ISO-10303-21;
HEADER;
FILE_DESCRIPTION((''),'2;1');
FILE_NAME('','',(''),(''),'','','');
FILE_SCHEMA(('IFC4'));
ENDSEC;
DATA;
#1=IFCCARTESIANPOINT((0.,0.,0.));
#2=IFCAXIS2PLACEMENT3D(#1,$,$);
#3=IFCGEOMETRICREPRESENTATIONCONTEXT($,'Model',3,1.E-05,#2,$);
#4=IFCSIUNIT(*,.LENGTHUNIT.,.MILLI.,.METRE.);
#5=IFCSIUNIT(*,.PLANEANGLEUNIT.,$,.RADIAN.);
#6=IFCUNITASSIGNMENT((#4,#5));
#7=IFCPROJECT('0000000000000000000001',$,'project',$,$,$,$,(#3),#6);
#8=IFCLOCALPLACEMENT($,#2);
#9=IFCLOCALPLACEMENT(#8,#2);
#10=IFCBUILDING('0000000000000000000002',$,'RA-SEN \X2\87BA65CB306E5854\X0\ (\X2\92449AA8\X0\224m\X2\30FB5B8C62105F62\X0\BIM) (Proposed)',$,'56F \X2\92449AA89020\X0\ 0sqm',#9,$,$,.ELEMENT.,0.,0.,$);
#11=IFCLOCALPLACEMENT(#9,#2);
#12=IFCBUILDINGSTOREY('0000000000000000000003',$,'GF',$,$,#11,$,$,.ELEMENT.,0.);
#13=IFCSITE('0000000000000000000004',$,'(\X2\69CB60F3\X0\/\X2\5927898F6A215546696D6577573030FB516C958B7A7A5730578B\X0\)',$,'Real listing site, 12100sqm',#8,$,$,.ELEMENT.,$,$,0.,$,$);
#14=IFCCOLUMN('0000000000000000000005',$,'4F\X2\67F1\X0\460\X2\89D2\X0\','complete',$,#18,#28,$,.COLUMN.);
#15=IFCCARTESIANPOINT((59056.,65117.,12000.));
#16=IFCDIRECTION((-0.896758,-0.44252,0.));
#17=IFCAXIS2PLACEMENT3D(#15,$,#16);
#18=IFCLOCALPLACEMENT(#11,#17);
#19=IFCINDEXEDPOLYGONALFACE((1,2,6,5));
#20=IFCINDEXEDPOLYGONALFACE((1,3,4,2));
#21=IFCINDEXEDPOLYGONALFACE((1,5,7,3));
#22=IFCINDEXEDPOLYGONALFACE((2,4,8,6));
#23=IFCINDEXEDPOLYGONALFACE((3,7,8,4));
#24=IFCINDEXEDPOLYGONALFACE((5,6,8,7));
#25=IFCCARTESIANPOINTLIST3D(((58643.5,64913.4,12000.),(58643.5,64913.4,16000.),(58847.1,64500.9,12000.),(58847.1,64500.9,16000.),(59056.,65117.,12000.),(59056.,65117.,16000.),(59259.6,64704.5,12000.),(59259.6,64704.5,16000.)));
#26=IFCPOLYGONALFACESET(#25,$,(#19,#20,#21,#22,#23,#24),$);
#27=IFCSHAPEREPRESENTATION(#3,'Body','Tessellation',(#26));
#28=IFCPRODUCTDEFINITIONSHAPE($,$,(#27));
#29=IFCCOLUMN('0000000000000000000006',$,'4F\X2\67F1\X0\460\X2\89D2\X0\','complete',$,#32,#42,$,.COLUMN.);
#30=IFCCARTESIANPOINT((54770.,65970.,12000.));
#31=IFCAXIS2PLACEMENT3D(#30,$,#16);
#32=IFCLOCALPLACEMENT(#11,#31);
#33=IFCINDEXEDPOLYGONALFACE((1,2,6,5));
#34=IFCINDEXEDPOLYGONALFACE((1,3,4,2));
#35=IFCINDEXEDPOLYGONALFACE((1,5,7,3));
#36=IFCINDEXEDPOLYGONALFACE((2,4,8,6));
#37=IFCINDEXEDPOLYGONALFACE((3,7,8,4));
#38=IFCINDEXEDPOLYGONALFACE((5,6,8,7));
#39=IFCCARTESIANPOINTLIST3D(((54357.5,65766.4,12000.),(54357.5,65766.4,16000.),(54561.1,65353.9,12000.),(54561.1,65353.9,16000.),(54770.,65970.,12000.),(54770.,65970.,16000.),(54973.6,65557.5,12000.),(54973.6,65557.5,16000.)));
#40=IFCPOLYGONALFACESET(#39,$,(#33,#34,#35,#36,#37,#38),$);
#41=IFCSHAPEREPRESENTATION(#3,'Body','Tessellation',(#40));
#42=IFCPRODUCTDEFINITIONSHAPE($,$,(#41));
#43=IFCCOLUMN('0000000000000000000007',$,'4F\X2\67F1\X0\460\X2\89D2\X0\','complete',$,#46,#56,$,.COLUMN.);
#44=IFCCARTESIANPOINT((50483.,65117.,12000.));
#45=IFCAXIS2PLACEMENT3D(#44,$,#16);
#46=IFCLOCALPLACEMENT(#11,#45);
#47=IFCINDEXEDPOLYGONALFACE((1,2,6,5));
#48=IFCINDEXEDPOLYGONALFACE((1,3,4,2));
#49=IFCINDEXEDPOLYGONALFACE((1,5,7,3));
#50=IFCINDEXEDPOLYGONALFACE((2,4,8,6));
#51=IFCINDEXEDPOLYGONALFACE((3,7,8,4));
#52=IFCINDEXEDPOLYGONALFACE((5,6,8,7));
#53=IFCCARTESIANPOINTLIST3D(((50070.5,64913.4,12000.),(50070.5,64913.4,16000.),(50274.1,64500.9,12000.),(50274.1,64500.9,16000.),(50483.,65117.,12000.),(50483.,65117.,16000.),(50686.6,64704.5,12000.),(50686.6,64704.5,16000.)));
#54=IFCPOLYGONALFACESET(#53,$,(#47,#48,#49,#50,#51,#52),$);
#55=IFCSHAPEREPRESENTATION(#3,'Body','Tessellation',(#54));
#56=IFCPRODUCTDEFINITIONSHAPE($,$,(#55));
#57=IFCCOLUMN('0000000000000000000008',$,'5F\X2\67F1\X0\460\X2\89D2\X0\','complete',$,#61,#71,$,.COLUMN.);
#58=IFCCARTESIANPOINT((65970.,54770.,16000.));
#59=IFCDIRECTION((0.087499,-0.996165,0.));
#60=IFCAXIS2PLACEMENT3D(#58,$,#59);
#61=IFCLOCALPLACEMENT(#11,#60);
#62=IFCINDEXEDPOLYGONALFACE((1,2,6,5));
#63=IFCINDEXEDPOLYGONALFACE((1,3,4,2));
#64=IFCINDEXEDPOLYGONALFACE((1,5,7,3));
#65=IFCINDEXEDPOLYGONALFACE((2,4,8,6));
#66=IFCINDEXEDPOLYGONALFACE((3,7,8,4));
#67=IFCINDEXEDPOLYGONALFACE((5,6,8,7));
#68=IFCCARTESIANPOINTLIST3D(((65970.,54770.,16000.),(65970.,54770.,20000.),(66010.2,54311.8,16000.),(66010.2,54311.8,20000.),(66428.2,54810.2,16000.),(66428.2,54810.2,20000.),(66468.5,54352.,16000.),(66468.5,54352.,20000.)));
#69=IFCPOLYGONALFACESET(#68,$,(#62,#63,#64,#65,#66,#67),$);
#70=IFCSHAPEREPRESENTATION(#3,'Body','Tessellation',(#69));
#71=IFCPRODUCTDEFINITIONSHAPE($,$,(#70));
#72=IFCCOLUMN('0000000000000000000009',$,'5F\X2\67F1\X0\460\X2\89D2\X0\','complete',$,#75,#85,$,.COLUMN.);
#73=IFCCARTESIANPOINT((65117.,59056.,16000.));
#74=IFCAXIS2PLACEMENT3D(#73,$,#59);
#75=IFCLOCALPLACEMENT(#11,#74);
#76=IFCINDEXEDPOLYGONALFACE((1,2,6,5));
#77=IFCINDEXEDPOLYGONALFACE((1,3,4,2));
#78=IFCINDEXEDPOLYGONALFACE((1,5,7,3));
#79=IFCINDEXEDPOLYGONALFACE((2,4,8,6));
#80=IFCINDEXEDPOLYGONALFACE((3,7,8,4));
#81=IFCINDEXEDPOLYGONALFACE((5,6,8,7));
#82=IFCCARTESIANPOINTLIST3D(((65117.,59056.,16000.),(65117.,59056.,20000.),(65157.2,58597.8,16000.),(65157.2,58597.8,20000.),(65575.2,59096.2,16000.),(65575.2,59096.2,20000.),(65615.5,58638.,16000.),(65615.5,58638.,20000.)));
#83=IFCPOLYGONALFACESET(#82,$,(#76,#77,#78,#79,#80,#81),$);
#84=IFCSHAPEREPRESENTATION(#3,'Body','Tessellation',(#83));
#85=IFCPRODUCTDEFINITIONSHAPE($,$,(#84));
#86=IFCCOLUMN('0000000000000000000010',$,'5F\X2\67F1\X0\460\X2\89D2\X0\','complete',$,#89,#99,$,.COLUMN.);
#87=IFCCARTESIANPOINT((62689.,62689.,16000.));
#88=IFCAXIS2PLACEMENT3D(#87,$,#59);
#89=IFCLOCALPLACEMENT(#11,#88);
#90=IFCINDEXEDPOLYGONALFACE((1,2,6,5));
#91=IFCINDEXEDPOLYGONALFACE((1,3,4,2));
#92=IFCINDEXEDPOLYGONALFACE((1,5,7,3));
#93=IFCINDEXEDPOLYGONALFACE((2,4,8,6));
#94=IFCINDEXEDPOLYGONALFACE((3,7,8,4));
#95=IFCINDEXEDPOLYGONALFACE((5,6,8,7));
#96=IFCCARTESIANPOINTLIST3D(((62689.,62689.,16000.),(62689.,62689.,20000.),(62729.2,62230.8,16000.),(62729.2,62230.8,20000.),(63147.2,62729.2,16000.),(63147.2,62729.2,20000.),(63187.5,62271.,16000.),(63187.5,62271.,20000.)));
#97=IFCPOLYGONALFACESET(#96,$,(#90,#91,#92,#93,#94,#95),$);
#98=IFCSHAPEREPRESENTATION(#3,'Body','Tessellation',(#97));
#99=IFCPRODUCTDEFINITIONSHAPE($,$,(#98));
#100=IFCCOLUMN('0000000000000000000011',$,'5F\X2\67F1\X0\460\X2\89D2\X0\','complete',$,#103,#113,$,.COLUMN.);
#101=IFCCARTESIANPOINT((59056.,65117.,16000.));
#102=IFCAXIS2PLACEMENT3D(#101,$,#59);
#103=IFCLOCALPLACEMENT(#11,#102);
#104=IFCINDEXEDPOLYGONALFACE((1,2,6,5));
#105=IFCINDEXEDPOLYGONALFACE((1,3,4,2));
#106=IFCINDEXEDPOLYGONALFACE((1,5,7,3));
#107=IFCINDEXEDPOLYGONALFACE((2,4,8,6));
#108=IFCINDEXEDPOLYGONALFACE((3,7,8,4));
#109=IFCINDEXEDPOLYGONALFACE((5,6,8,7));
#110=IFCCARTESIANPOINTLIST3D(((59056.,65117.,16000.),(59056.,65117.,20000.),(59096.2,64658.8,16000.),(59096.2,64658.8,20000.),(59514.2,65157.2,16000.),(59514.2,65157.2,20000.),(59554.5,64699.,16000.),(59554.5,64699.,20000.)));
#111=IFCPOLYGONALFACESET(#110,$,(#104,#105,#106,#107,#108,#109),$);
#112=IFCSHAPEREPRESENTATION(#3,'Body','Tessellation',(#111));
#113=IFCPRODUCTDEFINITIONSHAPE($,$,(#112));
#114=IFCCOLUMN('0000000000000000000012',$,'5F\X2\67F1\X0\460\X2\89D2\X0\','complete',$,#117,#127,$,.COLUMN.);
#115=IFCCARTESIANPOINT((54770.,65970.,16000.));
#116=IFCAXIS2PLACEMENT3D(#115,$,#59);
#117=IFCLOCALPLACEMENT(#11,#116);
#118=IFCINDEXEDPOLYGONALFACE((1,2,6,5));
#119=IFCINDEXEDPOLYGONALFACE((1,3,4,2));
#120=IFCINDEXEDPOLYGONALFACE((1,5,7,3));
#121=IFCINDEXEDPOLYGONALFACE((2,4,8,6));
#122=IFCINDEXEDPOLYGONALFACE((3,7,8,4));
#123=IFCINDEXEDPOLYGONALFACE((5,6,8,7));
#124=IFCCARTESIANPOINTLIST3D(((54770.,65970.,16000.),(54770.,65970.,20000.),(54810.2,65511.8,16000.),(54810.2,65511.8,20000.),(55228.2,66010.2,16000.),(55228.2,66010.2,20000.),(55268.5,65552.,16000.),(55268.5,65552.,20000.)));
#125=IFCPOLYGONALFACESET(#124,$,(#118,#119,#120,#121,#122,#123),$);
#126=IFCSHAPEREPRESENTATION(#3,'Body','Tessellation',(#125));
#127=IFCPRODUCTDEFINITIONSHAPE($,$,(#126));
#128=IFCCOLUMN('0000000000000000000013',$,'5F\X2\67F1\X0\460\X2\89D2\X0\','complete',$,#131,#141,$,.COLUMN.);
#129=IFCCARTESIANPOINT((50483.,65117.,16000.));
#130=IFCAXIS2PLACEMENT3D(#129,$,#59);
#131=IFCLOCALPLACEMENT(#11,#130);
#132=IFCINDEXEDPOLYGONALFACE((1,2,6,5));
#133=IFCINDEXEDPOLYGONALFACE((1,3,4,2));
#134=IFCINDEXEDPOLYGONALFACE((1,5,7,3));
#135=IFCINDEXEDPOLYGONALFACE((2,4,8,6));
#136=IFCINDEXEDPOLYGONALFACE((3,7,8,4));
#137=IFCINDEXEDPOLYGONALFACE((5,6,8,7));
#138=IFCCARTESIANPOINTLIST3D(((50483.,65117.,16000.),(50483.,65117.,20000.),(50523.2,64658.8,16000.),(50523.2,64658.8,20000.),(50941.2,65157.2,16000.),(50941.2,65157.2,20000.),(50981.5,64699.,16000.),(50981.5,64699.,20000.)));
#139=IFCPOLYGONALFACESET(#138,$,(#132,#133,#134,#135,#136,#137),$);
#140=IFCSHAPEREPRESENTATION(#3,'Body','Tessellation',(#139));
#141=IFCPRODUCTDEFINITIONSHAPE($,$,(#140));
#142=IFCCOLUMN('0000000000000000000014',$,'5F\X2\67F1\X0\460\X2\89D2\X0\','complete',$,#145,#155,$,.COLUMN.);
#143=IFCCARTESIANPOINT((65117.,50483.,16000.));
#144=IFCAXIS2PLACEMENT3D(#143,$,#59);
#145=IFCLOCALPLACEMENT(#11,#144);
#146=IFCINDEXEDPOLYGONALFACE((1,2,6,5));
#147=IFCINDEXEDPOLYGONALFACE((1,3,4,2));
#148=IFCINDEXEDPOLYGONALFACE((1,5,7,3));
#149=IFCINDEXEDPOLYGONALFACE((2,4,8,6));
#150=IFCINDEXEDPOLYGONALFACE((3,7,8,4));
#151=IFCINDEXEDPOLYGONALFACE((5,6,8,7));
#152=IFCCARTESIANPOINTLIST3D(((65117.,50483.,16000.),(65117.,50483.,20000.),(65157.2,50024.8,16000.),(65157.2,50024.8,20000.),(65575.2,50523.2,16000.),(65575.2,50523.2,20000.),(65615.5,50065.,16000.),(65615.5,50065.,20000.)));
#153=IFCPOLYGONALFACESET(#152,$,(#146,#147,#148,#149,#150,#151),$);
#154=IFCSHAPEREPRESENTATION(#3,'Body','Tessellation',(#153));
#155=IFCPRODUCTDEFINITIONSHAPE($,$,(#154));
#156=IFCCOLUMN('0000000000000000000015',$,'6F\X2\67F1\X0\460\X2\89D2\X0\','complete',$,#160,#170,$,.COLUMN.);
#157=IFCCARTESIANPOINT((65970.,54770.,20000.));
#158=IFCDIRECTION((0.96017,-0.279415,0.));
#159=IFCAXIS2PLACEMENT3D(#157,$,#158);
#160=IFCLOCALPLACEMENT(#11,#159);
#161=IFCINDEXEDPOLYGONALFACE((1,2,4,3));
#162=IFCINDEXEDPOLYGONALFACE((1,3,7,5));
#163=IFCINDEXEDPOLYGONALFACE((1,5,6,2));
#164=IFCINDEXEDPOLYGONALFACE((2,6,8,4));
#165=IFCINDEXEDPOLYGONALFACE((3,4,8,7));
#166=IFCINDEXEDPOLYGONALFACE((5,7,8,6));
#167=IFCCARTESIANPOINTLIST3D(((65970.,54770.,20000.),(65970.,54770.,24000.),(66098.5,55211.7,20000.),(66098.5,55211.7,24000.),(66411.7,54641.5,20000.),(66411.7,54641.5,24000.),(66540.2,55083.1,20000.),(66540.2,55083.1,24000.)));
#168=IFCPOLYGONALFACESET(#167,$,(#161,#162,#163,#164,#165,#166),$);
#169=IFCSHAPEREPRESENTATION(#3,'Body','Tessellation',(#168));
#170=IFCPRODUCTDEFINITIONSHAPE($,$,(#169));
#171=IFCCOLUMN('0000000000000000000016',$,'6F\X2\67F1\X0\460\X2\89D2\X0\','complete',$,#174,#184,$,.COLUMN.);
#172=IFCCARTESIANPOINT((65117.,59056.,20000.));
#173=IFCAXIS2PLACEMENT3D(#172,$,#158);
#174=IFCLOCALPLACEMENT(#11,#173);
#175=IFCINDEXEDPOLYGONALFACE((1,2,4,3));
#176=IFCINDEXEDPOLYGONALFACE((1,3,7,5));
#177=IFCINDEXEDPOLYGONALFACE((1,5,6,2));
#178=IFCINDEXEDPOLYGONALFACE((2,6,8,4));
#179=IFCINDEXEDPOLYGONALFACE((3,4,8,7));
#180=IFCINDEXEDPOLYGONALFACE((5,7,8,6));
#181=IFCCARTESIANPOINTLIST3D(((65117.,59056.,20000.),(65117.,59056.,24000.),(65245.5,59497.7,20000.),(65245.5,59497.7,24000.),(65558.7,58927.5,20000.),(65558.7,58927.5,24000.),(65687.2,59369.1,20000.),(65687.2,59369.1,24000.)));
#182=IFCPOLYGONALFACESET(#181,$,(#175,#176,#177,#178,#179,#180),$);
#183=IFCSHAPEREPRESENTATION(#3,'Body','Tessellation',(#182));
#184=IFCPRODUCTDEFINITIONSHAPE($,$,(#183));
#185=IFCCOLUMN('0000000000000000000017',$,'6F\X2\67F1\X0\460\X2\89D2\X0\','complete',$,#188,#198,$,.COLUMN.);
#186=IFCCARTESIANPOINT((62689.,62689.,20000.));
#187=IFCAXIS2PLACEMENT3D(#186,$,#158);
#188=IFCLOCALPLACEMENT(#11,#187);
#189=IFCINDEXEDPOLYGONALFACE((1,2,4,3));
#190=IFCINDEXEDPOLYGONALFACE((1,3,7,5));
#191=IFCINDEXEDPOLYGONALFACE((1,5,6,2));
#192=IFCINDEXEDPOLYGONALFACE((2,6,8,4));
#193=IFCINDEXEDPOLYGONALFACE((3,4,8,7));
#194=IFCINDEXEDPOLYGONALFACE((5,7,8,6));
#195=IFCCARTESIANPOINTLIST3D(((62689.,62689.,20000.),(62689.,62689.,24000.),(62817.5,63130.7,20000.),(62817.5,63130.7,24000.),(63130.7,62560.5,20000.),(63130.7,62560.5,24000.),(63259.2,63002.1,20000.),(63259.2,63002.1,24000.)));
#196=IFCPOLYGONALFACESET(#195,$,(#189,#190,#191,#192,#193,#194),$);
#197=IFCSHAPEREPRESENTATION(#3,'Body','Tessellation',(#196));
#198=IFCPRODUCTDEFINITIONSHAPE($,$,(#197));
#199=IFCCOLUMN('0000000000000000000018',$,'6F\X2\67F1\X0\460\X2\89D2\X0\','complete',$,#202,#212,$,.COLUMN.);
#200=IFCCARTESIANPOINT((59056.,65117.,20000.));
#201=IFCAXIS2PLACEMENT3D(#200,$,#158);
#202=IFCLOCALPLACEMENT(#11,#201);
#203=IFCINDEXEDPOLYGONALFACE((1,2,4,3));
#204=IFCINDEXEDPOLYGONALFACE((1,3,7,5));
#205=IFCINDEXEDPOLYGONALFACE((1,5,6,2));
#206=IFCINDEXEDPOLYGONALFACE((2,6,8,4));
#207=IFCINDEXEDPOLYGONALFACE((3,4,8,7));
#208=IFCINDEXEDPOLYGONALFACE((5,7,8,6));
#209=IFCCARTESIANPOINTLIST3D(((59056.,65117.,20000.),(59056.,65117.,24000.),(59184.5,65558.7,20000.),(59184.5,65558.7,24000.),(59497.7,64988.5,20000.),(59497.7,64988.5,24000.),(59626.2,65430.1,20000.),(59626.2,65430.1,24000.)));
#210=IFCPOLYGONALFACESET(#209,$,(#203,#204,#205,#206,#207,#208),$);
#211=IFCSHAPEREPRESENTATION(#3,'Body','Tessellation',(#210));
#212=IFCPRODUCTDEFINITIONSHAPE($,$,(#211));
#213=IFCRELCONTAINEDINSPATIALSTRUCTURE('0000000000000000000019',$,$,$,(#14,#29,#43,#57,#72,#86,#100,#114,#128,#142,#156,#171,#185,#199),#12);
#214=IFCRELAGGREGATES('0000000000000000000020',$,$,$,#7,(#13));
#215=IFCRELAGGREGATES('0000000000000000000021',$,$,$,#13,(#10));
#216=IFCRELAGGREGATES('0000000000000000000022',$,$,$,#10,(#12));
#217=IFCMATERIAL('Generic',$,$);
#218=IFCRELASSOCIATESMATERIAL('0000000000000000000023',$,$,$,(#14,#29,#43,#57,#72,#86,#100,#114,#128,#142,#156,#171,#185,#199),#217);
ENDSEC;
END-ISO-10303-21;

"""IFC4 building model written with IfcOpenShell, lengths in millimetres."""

from ifc_helpers import new_model, si_unit, frame, frame_2d, origin, place, context, project, spatial, rectangle, extrude, material, element, save


model = new_model("IFC4")

# Units and contexts
model_context = context("Model", 3, precision=1e-05, world=origin())
ifc_project = project(units=[si_unit("LENGTHUNIT", "METRE", prefix="MILLI"), si_unit("PLANEANGLEUNIT", "RADIAN")], contexts=[model_context])

# Site, building, storey
site_placement = place(None, origin())
site = spatial("IfcSite", under=ifc_project, at=site_placement, Name="(構想/大規模商業敷地・公開空地型)", ObjectType="Real listing site, 12100sqm", CompositionType="ELEMENT", RefElevation=0.0)
building_placement = place(site_placement, origin())
building = spatial("IfcBuilding", under=site, at=building_placement, Name="RA-SEN 螺旋の塔 (鉄骨224m・完成形BIM) (Proposed)", ObjectType="56F 鉄骨造 0sqm", CompositionType="ELEMENT", ElevationOfRefHeight=0.0, ElevationOfTerrain=0.0)
storey_placement = place(building_placement, origin())
storey = spatial("IfcBuildingStorey", under=building, at=storey_placement, Name="GF", CompositionType="ELEMENT", Elevation=0.0)

# Columns
ifc_material = material(Name="Generic")
column_1_placement = place(storey_placement, frame((59056.0, 65117.0, 12000.0), x_axis=(-0.896758, -0.44252, 0.0)))
element("IfcColumn", 1, at=column_1_placement, inside=storey, material=ifc_material, Name="4F柱460角", Description="complete", PredefinedType="COLUMN", context=model_context, shape_type="SweptSolid", body=[
    extrude(rectangle(XDim=460.0, YDim=460.0, at=frame_2d((230.0, 230.0))), frame((59056.0, 65117.0, 12000.0), x_axis=(-0.896758, -0.44252, 0.0)), (0.0, 0.0, 1.0), 4000.0),
])
column_2_placement = place(storey_placement, frame((54770.0, 65970.0, 12000.0), x_axis=(-0.896758, -0.44252, 0.0)))
element("IfcColumn", 2, at=column_2_placement, inside=storey, material=ifc_material, Name="4F柱460角", Description="complete", PredefinedType="COLUMN", context=model_context, shape_type="SweptSolid", body=[
    extrude(rectangle(XDim=460.0, YDim=460.0, at=frame_2d((230.0, 230.0))), frame((54770.0, 65970.0, 12000.0), x_axis=(-0.896758, -0.44252, 0.0)), (0.0, 0.0, 1.0), 4000.0),
])
column_3_placement = place(storey_placement, frame((50483.0, 65117.0, 12000.0), x_axis=(-0.896758, -0.44252, 0.0)))
element("IfcColumn", 3, at=column_3_placement, inside=storey, material=ifc_material, Name="4F柱460角", Description="complete", PredefinedType="COLUMN", context=model_context, shape_type="SweptSolid", body=[
    extrude(rectangle(XDim=460.0, YDim=460.0, at=frame_2d((230.0, 230.0))), frame((50483.0, 65117.0, 12000.0), x_axis=(-0.896758, -0.44252, 0.0)), (0.0, 0.0, 1.0), 4000.0),
])
column_4_placement = place(storey_placement, frame((65970.0, 54770.0, 16000.0), x_axis=(0.087499, -0.996165, 0.0)))
element("IfcColumn", 4, at=column_4_placement, inside=storey, material=ifc_material, Name="5F柱460角", Description="complete", PredefinedType="COLUMN", context=model_context, shape_type="SweptSolid", body=[
    extrude(rectangle(XDim=460.0, YDim=460.0, at=frame_2d((230.0, 230.0))), frame((65970.0, 54770.0, 16000.0), x_axis=(0.087499, -0.996165, 0.0)), (0.0, 0.0, 1.0), 4000.0),
])
column_5_placement = place(storey_placement, frame((65117.0, 59056.0, 16000.0), x_axis=(0.087499, -0.996165, 0.0)))
element("IfcColumn", 5, at=column_5_placement, inside=storey, material=ifc_material, Name="5F柱460角", Description="complete", PredefinedType="COLUMN", context=model_context, shape_type="SweptSolid", body=[
    extrude(rectangle(XDim=460.0, YDim=460.0, at=frame_2d((230.0, 230.0))), frame((65117.0, 59056.0, 16000.0), x_axis=(0.087499, -0.996165, 0.0)), (0.0, 0.0, 1.0), 4000.0),
])
column_6_placement = place(storey_placement, frame((62689.0, 62689.0, 16000.0), x_axis=(0.087499, -0.996165, 0.0)))
element("IfcColumn", 6, at=column_6_placement, inside=storey, material=ifc_material, Name="5F柱460角", Description="complete", PredefinedType="COLUMN", context=model_context, shape_type="SweptSolid", body=[
    extrude(rectangle(XDim=460.0, YDim=460.0, at=frame_2d((230.0, 230.0))), frame((62689.0, 62689.0, 16000.0), x_axis=(0.087499, -0.996165, 0.0)), (0.0, 0.0, 1.0), 4000.0),
])
column_7_placement = place(storey_placement, frame((59056.0, 65117.0, 16000.0), x_axis=(0.087499, -0.996165, 0.0)))
element("IfcColumn", 7, at=column_7_placement, inside=storey, material=ifc_material, Name="5F柱460角", Description="complete", PredefinedType="COLUMN", context=model_context, shape_type="SweptSolid", body=[
    extrude(rectangle(XDim=460.0, YDim=460.0, at=frame_2d((230.0, 230.0))), frame((59056.0, 65117.0, 16000.0), x_axis=(0.087499, -0.996165, 0.0)), (0.0, 0.0, 1.0), 4000.0),
])
column_8_placement = place(storey_placement, frame((54770.0, 65970.0, 16000.0), x_axis=(0.087499, -0.996165, 0.0)))
element("IfcColumn", 8, at=column_8_placement, inside=storey, material=ifc_material, Name="5F柱460角", Description="complete", PredefinedType="COLUMN", context=model_context, shape_type="SweptSolid", body=[
    extrude(rectangle(XDim=460.0, YDim=460.0, at=frame_2d((230.0, 230.0))), frame((54770.0, 65970.0, 16000.0), x_axis=(0.087499, -0.996165, 0.0)), (0.0, 0.0, 1.0), 4000.0),
])
column_9_placement = place(storey_placement, frame((50483.0, 65117.0, 16000.0), x_axis=(0.087499, -0.996165, 0.0)))
element("IfcColumn", 9, at=column_9_placement, inside=storey, material=ifc_material, Name="5F柱460角", Description="complete", PredefinedType="COLUMN", context=model_context, shape_type="SweptSolid", body=[
    extrude(rectangle(XDim=460.0, YDim=460.0, at=frame_2d((230.0, 230.0))), frame((50483.0, 65117.0, 16000.0), x_axis=(0.087499, -0.996165, 0.0)), (0.0, 0.0, 1.0), 4000.0),
])
column_10_placement = place(storey_placement, frame((65117.0, 50483.0, 16000.0), x_axis=(0.087499, -0.996165, 0.0)))
element("IfcColumn", 10, at=column_10_placement, inside=storey, material=ifc_material, Name="5F柱460角", Description="complete", PredefinedType="COLUMN", context=model_context, shape_type="SweptSolid", body=[
    extrude(rectangle(XDim=460.0, YDim=460.0, at=frame_2d((230.0, 230.0))), frame((65117.0, 50483.0, 16000.0), x_axis=(0.087499, -0.996165, 0.0)), (0.0, 0.0, 1.0), 4000.0),
])
column_11_placement = place(storey_placement, frame((65970.0, 54770.0, 20000.0), x_axis=(0.96017, -0.279415, 0.0)))
element("IfcColumn", 11, at=column_11_placement, inside=storey, material=ifc_material, Name="6F柱460角", Description="complete", PredefinedType="COLUMN", context=model_context, shape_type="SweptSolid", body=[
    extrude(rectangle(XDim=460.0, YDim=460.0, at=frame_2d((230.0, 230.0))), frame((65970.0, 54770.0, 20000.0), x_axis=(0.96017, -0.279415, 0.0)), (0.0, 0.0, 1.0), 4000.0),
])
column_12_placement = place(storey_placement, frame((65117.0, 59056.0, 20000.0), x_axis=(0.96017, -0.279415, 0.0)))
element("IfcColumn", 12, at=column_12_placement, inside=storey, material=ifc_material, Name="6F柱460角", Description="complete", PredefinedType="COLUMN", context=model_context, shape_type="SweptSolid", body=[
    extrude(rectangle(XDim=460.0, YDim=460.0, at=frame_2d((230.0, 230.0))), frame((65117.0, 59056.0, 20000.0), x_axis=(0.96017, -0.279415, 0.0)), (0.0, 0.0, 1.0), 4000.0),
])
column_13_placement = place(storey_placement, frame((62689.0, 62689.0, 20000.0), x_axis=(0.96017, -0.279415, 0.0)))
element("IfcColumn", 13, at=column_13_placement, inside=storey, material=ifc_material, Name="6F柱460角", Description="complete", PredefinedType="COLUMN", context=model_context, shape_type="SweptSolid", body=[
    extrude(rectangle(XDim=460.0, YDim=460.0, at=frame_2d((230.0, 230.0))), frame((62689.0, 62689.0, 20000.0), x_axis=(0.96017, -0.279415, 0.0)), (0.0, 0.0, 1.0), 4000.0),
])
column_14_placement = place(storey_placement, frame((59056.0, 65117.0, 20000.0), x_axis=(0.96017, -0.279415, 0.0)))
element("IfcColumn", 14, at=column_14_placement, inside=storey, material=ifc_material, Name="6F柱460角", Description="complete", PredefinedType="COLUMN", context=model_context, shape_type="SweptSolid", body=[
    extrude(rectangle(XDim=460.0, YDim=460.0, at=frame_2d((230.0, 230.0))), frame((59056.0, 65117.0, 20000.0), x_axis=(0.96017, -0.279415, 0.0)), (0.0, 0.0, 1.0), 4000.0),
])

save(model, "model.ifc")
